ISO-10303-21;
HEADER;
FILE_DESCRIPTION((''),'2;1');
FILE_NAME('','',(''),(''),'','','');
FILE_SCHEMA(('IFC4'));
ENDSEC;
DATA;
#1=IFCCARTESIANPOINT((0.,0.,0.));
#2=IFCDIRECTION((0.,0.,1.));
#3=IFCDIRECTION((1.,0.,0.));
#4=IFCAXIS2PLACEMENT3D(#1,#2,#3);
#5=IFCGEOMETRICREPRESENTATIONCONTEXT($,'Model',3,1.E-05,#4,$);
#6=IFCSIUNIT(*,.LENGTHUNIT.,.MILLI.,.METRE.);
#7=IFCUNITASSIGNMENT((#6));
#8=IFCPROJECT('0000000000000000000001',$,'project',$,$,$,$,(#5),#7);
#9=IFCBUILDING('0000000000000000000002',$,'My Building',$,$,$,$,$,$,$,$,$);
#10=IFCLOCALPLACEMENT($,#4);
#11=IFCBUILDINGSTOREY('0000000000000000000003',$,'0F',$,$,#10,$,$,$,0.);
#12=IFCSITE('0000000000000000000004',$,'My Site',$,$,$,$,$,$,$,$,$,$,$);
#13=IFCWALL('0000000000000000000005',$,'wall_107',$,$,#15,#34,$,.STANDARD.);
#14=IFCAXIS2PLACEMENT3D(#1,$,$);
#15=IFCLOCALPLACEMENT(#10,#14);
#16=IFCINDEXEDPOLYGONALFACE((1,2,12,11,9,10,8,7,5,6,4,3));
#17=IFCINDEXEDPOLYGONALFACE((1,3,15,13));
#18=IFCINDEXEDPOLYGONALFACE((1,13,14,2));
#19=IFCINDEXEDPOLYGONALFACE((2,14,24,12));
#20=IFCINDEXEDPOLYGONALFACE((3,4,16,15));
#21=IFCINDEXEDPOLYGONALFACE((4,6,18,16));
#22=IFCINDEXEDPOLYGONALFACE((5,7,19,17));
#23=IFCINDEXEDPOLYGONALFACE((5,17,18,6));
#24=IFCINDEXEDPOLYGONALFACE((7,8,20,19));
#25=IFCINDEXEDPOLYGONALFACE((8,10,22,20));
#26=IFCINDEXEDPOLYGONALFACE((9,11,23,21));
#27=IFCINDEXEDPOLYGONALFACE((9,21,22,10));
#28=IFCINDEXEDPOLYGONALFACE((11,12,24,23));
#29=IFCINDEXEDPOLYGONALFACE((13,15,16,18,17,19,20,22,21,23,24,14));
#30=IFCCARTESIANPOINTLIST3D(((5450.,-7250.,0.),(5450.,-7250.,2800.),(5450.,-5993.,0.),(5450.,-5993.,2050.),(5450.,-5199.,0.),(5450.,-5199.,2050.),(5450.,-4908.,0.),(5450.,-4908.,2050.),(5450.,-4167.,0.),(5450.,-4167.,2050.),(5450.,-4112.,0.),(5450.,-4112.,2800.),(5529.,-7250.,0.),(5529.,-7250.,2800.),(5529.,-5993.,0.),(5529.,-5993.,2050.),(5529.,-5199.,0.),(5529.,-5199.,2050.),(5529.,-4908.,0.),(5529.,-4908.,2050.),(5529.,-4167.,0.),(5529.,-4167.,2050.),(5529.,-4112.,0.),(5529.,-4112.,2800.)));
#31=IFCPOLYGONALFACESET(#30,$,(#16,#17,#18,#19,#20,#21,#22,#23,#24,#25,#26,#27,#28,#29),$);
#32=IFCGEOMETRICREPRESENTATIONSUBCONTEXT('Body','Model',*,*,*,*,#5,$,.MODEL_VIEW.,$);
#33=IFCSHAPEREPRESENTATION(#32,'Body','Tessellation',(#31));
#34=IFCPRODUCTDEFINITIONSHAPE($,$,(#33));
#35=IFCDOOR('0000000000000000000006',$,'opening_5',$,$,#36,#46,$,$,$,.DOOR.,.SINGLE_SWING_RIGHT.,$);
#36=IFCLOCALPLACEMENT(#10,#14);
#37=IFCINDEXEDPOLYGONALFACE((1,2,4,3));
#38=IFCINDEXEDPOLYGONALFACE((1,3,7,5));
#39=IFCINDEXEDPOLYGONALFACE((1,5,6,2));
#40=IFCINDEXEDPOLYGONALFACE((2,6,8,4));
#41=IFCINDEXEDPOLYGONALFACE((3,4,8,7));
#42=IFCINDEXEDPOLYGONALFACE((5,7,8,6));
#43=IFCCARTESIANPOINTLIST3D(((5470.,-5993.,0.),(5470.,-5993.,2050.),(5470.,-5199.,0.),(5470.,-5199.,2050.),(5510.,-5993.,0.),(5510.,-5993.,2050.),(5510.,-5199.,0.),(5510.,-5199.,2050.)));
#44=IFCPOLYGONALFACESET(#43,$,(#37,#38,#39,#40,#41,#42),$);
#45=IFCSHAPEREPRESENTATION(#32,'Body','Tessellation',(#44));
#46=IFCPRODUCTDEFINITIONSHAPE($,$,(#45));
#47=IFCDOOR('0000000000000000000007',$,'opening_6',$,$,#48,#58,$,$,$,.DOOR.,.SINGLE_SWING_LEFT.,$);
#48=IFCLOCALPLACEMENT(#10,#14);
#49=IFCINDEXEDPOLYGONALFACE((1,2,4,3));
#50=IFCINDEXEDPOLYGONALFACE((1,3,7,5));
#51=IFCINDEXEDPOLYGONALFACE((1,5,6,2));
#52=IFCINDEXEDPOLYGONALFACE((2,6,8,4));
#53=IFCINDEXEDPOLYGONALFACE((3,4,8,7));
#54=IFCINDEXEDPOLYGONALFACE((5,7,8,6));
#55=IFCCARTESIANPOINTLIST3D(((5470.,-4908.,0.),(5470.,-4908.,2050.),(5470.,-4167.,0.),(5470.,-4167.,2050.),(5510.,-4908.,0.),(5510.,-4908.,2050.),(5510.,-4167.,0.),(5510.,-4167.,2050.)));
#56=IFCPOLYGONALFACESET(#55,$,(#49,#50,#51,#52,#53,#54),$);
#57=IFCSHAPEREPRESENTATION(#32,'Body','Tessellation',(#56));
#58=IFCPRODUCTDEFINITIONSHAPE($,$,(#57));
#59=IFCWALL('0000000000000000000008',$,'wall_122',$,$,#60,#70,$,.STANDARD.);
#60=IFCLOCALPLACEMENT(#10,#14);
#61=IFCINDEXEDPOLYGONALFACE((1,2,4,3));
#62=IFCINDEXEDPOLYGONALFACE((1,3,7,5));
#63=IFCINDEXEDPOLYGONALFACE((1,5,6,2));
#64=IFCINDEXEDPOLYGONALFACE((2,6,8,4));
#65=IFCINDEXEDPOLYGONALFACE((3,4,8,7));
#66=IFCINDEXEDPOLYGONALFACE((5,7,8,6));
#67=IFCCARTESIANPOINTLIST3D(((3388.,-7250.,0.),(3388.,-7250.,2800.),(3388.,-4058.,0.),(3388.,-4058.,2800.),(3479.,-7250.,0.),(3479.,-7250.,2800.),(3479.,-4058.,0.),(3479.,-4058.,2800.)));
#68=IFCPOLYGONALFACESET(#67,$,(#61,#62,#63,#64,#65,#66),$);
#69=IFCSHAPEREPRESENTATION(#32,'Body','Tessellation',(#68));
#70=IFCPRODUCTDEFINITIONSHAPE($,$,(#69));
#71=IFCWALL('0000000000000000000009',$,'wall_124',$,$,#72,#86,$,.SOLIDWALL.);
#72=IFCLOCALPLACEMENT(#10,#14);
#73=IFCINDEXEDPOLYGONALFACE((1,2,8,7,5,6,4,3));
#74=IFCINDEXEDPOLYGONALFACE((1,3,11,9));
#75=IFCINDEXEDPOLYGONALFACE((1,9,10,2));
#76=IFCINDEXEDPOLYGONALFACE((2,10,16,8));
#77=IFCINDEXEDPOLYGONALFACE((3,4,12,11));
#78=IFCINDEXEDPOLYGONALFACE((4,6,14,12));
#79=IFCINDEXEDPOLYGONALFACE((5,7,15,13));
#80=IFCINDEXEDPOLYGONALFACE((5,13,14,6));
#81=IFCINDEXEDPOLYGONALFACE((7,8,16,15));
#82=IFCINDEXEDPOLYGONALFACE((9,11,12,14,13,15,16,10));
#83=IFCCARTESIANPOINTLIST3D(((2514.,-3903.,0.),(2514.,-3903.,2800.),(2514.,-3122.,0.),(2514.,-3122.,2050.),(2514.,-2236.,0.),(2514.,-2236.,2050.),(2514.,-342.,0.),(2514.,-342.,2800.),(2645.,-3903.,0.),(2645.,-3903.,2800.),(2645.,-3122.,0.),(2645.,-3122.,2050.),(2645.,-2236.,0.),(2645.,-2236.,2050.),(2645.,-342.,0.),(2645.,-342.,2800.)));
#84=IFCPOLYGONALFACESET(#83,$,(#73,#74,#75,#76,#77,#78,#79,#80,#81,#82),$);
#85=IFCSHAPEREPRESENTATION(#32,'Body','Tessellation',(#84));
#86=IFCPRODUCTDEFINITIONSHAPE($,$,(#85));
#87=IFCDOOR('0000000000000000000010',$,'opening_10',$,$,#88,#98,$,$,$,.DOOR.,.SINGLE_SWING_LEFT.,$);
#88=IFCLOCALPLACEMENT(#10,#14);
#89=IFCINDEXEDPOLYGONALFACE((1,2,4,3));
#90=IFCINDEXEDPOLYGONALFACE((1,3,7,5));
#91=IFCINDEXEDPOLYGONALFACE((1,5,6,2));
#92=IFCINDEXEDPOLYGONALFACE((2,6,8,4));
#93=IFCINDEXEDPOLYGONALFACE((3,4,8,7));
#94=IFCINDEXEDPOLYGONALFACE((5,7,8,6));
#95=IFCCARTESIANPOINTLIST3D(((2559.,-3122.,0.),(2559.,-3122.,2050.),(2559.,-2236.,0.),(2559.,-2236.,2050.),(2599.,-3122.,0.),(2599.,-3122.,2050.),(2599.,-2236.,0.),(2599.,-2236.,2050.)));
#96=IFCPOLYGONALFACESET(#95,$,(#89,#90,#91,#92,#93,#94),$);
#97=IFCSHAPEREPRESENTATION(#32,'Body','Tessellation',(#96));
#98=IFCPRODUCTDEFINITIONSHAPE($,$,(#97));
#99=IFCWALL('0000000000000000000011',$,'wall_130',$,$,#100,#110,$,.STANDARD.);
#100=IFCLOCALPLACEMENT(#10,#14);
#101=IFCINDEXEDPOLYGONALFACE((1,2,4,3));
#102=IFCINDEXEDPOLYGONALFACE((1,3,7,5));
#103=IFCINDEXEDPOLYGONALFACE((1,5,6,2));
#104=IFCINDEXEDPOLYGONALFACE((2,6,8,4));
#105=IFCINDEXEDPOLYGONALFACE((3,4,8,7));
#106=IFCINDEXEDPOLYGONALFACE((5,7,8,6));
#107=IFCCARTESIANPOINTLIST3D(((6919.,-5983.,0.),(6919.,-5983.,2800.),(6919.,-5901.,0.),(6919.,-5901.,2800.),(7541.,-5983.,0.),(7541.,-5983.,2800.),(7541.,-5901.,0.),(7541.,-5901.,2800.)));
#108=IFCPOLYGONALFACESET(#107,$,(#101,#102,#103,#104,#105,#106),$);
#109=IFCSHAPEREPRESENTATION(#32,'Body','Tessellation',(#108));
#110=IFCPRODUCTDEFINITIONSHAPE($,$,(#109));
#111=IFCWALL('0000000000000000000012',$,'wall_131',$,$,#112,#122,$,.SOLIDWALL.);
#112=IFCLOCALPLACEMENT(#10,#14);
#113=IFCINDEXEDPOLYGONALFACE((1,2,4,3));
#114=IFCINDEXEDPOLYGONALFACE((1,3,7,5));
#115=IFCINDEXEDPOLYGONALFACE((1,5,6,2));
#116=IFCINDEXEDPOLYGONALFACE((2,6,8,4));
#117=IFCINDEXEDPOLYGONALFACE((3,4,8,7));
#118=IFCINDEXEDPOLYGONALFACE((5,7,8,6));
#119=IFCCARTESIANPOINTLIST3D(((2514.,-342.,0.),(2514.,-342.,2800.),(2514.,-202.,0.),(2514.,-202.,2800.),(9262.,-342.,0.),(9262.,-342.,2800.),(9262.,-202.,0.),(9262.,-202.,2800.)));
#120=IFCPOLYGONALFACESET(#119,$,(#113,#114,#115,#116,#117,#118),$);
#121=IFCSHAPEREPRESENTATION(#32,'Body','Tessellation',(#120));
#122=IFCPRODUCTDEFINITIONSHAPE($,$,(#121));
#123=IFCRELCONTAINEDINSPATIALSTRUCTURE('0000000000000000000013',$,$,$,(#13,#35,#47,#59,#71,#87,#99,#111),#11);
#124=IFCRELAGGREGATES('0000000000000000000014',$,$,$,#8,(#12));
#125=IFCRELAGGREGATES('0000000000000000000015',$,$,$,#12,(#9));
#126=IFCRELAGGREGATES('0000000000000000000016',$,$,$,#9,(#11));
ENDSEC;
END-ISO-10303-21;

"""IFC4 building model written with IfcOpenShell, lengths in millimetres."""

from ifc_helpers import new_model, si_unit, origin_with_axes, place, context, subcontext, project, spatial, indexed_curve, outline, extrude, element, fill, save


model = new_model("IFC4")

# Units and contexts
model_context = context("Model", 3, precision=1e-05, world=origin_with_axes())
body_context = subcontext(model_context, "Body", "Model", "MODEL_VIEW")
ifc_project = project(units=[si_unit("LENGTHUNIT", "METRE", prefix="MILLI")], contexts=[model_context])

# Site, building, storey
site = spatial("IfcSite", under=ifc_project, Name="My Site")
building = spatial("IfcBuilding", under=site, Name="My Building")
storey_placement = place(None, origin_with_axes())
storey = spatial("IfcBuildingStorey", under=building, at=storey_placement, Name="0F", Elevation=0.0)

# Wall, openings, doors
wall_1_placement = place(storey_placement, origin_with_axes())
wall_1 = element("IfcWall", 1, at=wall_1_placement, inside=storey, Name="wall_107", PredefinedType="STANDARD", context=body_context, shape_type="SweptSolid", body=[
    extrude(outline(indexed_curve([(5450.0, -4112.0), (5450.0, -7250.0), (5529.0, -7250.0), (5529.0, -4112.0), (5450.0, -4112.0)])), None, (0.0, 0.0, 1.0), 2800.0),
])
opening_1_placement = place(wall_1_placement, origin_with_axes())
opening_1 = element("IfcOpeningElement", 2, at=opening_1_placement, cuts=wall_1, ObjectType="Opening", context=body_context, shape_type="SweptSolid", body=[
    extrude(outline(indexed_curve([(5384.0, -5993.0), (5596.0, -5993.0), (5596.0, -5199.0), (5384.0, -5199.0), (5384.0, -5993.0)])), None, (0.0, 0.0, 1.0), 2050.0),
])
opening_2_placement = place(wall_1_placement, origin_with_axes())
opening_2 = element("IfcOpeningElement", 3, at=opening_2_placement, cuts=wall_1, ObjectType="Opening", context=body_context, shape_type="SweptSolid", body=[
    extrude(outline(indexed_curve([(5384.0, -4908.0), (5596.0, -4908.0), (5596.0, -4167.0), (5384.0, -4167.0), (5384.0, -4908.0)])), None, (0.0, 0.0, 1.0), 2050.0),
])
door_1_placement = place(opening_1_placement, origin_with_axes())
door_1 = element("IfcDoor", 4, at=door_1_placement, inside=storey, Name="opening_5", OperationType="SINGLE_SWING_RIGHT", PredefinedType="DOOR", context=body_context, shape_type="SweptSolid", body=[
    extrude(outline(indexed_curve([(5470.0, -5993.0), (5510.0, -5993.0), (5510.0, -5199.0), (5470.0, -5199.0), (5470.0, -5993.0)])), None, (0.0, 0.0, 1.0), 2050.0),
])
fill(opening_1, door_1)
door_2_placement = place(opening_2_placement, origin_with_axes())
door_2 = element("IfcDoor", 5, at=door_2_placement, inside=storey, Name="opening_6", OperationType="SINGLE_SWING_LEFT", PredefinedType="DOOR", context=body_context, shape_type="SweptSolid", body=[
    extrude(outline(indexed_curve([(5470.0, -4908.0), (5510.0, -4908.0), (5510.0, -4167.0), (5470.0, -4167.0), (5470.0, -4908.0)])), None, (0.0, 0.0, 1.0), 2050.0),
])
fill(opening_2, door_2)

# Wall
wall_2_placement = place(storey_placement, origin_with_axes())
element("IfcWall", 6, at=wall_2_placement, inside=storey, Name="wall_122", PredefinedType="STANDARD", context=body_context, shape_type="SweptSolid", body=[
    extrude(outline(indexed_curve([(3388.0, -4058.0), (3388.0, -7250.0), (3479.0, -7250.0), (3479.0, -4058.0), (3388.0, -4058.0)])), None, (0.0, 0.0, 1.0), 2800.0),
])

# Wall, opening, door
wall_3_placement = place(storey_placement, origin_with_axes())
wall_3 = element("IfcWall", 7, at=wall_3_placement, inside=storey, Name="wall_124", PredefinedType="SOLIDWALL", context=body_context, shape_type="SweptSolid", body=[
    extrude(outline(indexed_curve([(2514.0, -342.0), (2514.0, -3903.0), (2645.0, -3903.0), (2645.0, -342.0), (2514.0, -342.0)])), None, (0.0, 0.0, 1.0), 2800.0),
])
opening_3_placement = place(wall_3_placement, origin_with_axes())
opening_3 = element("IfcOpeningElement", 8, at=opening_3_placement, cuts=wall_3, ObjectType="Opening", context=body_context, shape_type="SweptSolid", body=[
    extrude(outline(indexed_curve([(2447.0, -3122.0), (2711.0, -3122.0), (2711.0, -2236.0), (2447.0, -2236.0), (2447.0, -3122.0)])), None, (0.0, 0.0, 1.0), 2050.0),
])
door_3_placement = place(opening_3_placement, origin_with_axes())
door_3 = element("IfcDoor", 9, at=door_3_placement, inside=storey, Name="opening_10", OperationType="SINGLE_SWING_LEFT", PredefinedType="DOOR", context=body_context, shape_type="SweptSolid", body=[
    extrude(outline(indexed_curve([(2559.0, -3122.0), (2599.0, -3122.0), (2599.0, -2236.0), (2559.0, -2236.0), (2559.0, -3122.0)])), None, (0.0, 0.0, 1.0), 2050.0),
])
fill(opening_3, door_3)

# Walls
wall_4_placement = place(storey_placement, origin_with_axes())
element("IfcWall", 10, at=wall_4_placement, inside=storey, Name="wall_130", PredefinedType="STANDARD", context=body_context, shape_type="SweptSolid", body=[
    extrude(outline(indexed_curve([(6919.0, -5983.0), (7541.0, -5983.0), (7541.0, -5901.0), (6919.0, -5901.0), (6919.0, -5983.0)])), None, (0.0, 0.0, 1.0), 2800.0),
])
wall_5_placement = place(storey_placement, origin_with_axes())
element("IfcWall", 11, at=wall_5_placement, inside=storey, Name="wall_131", PredefinedType="SOLIDWALL", context=body_context, shape_type="SweptSolid", body=[
    extrude(outline(indexed_curve([(2514.0, -342.0), (9262.0, -342.0), (9262.0, -202.0), (2514.0, -202.0), (2514.0, -342.0)])), None, (0.0, 0.0, 1.0), 2800.0),
])

save(model, "model.ifc")
